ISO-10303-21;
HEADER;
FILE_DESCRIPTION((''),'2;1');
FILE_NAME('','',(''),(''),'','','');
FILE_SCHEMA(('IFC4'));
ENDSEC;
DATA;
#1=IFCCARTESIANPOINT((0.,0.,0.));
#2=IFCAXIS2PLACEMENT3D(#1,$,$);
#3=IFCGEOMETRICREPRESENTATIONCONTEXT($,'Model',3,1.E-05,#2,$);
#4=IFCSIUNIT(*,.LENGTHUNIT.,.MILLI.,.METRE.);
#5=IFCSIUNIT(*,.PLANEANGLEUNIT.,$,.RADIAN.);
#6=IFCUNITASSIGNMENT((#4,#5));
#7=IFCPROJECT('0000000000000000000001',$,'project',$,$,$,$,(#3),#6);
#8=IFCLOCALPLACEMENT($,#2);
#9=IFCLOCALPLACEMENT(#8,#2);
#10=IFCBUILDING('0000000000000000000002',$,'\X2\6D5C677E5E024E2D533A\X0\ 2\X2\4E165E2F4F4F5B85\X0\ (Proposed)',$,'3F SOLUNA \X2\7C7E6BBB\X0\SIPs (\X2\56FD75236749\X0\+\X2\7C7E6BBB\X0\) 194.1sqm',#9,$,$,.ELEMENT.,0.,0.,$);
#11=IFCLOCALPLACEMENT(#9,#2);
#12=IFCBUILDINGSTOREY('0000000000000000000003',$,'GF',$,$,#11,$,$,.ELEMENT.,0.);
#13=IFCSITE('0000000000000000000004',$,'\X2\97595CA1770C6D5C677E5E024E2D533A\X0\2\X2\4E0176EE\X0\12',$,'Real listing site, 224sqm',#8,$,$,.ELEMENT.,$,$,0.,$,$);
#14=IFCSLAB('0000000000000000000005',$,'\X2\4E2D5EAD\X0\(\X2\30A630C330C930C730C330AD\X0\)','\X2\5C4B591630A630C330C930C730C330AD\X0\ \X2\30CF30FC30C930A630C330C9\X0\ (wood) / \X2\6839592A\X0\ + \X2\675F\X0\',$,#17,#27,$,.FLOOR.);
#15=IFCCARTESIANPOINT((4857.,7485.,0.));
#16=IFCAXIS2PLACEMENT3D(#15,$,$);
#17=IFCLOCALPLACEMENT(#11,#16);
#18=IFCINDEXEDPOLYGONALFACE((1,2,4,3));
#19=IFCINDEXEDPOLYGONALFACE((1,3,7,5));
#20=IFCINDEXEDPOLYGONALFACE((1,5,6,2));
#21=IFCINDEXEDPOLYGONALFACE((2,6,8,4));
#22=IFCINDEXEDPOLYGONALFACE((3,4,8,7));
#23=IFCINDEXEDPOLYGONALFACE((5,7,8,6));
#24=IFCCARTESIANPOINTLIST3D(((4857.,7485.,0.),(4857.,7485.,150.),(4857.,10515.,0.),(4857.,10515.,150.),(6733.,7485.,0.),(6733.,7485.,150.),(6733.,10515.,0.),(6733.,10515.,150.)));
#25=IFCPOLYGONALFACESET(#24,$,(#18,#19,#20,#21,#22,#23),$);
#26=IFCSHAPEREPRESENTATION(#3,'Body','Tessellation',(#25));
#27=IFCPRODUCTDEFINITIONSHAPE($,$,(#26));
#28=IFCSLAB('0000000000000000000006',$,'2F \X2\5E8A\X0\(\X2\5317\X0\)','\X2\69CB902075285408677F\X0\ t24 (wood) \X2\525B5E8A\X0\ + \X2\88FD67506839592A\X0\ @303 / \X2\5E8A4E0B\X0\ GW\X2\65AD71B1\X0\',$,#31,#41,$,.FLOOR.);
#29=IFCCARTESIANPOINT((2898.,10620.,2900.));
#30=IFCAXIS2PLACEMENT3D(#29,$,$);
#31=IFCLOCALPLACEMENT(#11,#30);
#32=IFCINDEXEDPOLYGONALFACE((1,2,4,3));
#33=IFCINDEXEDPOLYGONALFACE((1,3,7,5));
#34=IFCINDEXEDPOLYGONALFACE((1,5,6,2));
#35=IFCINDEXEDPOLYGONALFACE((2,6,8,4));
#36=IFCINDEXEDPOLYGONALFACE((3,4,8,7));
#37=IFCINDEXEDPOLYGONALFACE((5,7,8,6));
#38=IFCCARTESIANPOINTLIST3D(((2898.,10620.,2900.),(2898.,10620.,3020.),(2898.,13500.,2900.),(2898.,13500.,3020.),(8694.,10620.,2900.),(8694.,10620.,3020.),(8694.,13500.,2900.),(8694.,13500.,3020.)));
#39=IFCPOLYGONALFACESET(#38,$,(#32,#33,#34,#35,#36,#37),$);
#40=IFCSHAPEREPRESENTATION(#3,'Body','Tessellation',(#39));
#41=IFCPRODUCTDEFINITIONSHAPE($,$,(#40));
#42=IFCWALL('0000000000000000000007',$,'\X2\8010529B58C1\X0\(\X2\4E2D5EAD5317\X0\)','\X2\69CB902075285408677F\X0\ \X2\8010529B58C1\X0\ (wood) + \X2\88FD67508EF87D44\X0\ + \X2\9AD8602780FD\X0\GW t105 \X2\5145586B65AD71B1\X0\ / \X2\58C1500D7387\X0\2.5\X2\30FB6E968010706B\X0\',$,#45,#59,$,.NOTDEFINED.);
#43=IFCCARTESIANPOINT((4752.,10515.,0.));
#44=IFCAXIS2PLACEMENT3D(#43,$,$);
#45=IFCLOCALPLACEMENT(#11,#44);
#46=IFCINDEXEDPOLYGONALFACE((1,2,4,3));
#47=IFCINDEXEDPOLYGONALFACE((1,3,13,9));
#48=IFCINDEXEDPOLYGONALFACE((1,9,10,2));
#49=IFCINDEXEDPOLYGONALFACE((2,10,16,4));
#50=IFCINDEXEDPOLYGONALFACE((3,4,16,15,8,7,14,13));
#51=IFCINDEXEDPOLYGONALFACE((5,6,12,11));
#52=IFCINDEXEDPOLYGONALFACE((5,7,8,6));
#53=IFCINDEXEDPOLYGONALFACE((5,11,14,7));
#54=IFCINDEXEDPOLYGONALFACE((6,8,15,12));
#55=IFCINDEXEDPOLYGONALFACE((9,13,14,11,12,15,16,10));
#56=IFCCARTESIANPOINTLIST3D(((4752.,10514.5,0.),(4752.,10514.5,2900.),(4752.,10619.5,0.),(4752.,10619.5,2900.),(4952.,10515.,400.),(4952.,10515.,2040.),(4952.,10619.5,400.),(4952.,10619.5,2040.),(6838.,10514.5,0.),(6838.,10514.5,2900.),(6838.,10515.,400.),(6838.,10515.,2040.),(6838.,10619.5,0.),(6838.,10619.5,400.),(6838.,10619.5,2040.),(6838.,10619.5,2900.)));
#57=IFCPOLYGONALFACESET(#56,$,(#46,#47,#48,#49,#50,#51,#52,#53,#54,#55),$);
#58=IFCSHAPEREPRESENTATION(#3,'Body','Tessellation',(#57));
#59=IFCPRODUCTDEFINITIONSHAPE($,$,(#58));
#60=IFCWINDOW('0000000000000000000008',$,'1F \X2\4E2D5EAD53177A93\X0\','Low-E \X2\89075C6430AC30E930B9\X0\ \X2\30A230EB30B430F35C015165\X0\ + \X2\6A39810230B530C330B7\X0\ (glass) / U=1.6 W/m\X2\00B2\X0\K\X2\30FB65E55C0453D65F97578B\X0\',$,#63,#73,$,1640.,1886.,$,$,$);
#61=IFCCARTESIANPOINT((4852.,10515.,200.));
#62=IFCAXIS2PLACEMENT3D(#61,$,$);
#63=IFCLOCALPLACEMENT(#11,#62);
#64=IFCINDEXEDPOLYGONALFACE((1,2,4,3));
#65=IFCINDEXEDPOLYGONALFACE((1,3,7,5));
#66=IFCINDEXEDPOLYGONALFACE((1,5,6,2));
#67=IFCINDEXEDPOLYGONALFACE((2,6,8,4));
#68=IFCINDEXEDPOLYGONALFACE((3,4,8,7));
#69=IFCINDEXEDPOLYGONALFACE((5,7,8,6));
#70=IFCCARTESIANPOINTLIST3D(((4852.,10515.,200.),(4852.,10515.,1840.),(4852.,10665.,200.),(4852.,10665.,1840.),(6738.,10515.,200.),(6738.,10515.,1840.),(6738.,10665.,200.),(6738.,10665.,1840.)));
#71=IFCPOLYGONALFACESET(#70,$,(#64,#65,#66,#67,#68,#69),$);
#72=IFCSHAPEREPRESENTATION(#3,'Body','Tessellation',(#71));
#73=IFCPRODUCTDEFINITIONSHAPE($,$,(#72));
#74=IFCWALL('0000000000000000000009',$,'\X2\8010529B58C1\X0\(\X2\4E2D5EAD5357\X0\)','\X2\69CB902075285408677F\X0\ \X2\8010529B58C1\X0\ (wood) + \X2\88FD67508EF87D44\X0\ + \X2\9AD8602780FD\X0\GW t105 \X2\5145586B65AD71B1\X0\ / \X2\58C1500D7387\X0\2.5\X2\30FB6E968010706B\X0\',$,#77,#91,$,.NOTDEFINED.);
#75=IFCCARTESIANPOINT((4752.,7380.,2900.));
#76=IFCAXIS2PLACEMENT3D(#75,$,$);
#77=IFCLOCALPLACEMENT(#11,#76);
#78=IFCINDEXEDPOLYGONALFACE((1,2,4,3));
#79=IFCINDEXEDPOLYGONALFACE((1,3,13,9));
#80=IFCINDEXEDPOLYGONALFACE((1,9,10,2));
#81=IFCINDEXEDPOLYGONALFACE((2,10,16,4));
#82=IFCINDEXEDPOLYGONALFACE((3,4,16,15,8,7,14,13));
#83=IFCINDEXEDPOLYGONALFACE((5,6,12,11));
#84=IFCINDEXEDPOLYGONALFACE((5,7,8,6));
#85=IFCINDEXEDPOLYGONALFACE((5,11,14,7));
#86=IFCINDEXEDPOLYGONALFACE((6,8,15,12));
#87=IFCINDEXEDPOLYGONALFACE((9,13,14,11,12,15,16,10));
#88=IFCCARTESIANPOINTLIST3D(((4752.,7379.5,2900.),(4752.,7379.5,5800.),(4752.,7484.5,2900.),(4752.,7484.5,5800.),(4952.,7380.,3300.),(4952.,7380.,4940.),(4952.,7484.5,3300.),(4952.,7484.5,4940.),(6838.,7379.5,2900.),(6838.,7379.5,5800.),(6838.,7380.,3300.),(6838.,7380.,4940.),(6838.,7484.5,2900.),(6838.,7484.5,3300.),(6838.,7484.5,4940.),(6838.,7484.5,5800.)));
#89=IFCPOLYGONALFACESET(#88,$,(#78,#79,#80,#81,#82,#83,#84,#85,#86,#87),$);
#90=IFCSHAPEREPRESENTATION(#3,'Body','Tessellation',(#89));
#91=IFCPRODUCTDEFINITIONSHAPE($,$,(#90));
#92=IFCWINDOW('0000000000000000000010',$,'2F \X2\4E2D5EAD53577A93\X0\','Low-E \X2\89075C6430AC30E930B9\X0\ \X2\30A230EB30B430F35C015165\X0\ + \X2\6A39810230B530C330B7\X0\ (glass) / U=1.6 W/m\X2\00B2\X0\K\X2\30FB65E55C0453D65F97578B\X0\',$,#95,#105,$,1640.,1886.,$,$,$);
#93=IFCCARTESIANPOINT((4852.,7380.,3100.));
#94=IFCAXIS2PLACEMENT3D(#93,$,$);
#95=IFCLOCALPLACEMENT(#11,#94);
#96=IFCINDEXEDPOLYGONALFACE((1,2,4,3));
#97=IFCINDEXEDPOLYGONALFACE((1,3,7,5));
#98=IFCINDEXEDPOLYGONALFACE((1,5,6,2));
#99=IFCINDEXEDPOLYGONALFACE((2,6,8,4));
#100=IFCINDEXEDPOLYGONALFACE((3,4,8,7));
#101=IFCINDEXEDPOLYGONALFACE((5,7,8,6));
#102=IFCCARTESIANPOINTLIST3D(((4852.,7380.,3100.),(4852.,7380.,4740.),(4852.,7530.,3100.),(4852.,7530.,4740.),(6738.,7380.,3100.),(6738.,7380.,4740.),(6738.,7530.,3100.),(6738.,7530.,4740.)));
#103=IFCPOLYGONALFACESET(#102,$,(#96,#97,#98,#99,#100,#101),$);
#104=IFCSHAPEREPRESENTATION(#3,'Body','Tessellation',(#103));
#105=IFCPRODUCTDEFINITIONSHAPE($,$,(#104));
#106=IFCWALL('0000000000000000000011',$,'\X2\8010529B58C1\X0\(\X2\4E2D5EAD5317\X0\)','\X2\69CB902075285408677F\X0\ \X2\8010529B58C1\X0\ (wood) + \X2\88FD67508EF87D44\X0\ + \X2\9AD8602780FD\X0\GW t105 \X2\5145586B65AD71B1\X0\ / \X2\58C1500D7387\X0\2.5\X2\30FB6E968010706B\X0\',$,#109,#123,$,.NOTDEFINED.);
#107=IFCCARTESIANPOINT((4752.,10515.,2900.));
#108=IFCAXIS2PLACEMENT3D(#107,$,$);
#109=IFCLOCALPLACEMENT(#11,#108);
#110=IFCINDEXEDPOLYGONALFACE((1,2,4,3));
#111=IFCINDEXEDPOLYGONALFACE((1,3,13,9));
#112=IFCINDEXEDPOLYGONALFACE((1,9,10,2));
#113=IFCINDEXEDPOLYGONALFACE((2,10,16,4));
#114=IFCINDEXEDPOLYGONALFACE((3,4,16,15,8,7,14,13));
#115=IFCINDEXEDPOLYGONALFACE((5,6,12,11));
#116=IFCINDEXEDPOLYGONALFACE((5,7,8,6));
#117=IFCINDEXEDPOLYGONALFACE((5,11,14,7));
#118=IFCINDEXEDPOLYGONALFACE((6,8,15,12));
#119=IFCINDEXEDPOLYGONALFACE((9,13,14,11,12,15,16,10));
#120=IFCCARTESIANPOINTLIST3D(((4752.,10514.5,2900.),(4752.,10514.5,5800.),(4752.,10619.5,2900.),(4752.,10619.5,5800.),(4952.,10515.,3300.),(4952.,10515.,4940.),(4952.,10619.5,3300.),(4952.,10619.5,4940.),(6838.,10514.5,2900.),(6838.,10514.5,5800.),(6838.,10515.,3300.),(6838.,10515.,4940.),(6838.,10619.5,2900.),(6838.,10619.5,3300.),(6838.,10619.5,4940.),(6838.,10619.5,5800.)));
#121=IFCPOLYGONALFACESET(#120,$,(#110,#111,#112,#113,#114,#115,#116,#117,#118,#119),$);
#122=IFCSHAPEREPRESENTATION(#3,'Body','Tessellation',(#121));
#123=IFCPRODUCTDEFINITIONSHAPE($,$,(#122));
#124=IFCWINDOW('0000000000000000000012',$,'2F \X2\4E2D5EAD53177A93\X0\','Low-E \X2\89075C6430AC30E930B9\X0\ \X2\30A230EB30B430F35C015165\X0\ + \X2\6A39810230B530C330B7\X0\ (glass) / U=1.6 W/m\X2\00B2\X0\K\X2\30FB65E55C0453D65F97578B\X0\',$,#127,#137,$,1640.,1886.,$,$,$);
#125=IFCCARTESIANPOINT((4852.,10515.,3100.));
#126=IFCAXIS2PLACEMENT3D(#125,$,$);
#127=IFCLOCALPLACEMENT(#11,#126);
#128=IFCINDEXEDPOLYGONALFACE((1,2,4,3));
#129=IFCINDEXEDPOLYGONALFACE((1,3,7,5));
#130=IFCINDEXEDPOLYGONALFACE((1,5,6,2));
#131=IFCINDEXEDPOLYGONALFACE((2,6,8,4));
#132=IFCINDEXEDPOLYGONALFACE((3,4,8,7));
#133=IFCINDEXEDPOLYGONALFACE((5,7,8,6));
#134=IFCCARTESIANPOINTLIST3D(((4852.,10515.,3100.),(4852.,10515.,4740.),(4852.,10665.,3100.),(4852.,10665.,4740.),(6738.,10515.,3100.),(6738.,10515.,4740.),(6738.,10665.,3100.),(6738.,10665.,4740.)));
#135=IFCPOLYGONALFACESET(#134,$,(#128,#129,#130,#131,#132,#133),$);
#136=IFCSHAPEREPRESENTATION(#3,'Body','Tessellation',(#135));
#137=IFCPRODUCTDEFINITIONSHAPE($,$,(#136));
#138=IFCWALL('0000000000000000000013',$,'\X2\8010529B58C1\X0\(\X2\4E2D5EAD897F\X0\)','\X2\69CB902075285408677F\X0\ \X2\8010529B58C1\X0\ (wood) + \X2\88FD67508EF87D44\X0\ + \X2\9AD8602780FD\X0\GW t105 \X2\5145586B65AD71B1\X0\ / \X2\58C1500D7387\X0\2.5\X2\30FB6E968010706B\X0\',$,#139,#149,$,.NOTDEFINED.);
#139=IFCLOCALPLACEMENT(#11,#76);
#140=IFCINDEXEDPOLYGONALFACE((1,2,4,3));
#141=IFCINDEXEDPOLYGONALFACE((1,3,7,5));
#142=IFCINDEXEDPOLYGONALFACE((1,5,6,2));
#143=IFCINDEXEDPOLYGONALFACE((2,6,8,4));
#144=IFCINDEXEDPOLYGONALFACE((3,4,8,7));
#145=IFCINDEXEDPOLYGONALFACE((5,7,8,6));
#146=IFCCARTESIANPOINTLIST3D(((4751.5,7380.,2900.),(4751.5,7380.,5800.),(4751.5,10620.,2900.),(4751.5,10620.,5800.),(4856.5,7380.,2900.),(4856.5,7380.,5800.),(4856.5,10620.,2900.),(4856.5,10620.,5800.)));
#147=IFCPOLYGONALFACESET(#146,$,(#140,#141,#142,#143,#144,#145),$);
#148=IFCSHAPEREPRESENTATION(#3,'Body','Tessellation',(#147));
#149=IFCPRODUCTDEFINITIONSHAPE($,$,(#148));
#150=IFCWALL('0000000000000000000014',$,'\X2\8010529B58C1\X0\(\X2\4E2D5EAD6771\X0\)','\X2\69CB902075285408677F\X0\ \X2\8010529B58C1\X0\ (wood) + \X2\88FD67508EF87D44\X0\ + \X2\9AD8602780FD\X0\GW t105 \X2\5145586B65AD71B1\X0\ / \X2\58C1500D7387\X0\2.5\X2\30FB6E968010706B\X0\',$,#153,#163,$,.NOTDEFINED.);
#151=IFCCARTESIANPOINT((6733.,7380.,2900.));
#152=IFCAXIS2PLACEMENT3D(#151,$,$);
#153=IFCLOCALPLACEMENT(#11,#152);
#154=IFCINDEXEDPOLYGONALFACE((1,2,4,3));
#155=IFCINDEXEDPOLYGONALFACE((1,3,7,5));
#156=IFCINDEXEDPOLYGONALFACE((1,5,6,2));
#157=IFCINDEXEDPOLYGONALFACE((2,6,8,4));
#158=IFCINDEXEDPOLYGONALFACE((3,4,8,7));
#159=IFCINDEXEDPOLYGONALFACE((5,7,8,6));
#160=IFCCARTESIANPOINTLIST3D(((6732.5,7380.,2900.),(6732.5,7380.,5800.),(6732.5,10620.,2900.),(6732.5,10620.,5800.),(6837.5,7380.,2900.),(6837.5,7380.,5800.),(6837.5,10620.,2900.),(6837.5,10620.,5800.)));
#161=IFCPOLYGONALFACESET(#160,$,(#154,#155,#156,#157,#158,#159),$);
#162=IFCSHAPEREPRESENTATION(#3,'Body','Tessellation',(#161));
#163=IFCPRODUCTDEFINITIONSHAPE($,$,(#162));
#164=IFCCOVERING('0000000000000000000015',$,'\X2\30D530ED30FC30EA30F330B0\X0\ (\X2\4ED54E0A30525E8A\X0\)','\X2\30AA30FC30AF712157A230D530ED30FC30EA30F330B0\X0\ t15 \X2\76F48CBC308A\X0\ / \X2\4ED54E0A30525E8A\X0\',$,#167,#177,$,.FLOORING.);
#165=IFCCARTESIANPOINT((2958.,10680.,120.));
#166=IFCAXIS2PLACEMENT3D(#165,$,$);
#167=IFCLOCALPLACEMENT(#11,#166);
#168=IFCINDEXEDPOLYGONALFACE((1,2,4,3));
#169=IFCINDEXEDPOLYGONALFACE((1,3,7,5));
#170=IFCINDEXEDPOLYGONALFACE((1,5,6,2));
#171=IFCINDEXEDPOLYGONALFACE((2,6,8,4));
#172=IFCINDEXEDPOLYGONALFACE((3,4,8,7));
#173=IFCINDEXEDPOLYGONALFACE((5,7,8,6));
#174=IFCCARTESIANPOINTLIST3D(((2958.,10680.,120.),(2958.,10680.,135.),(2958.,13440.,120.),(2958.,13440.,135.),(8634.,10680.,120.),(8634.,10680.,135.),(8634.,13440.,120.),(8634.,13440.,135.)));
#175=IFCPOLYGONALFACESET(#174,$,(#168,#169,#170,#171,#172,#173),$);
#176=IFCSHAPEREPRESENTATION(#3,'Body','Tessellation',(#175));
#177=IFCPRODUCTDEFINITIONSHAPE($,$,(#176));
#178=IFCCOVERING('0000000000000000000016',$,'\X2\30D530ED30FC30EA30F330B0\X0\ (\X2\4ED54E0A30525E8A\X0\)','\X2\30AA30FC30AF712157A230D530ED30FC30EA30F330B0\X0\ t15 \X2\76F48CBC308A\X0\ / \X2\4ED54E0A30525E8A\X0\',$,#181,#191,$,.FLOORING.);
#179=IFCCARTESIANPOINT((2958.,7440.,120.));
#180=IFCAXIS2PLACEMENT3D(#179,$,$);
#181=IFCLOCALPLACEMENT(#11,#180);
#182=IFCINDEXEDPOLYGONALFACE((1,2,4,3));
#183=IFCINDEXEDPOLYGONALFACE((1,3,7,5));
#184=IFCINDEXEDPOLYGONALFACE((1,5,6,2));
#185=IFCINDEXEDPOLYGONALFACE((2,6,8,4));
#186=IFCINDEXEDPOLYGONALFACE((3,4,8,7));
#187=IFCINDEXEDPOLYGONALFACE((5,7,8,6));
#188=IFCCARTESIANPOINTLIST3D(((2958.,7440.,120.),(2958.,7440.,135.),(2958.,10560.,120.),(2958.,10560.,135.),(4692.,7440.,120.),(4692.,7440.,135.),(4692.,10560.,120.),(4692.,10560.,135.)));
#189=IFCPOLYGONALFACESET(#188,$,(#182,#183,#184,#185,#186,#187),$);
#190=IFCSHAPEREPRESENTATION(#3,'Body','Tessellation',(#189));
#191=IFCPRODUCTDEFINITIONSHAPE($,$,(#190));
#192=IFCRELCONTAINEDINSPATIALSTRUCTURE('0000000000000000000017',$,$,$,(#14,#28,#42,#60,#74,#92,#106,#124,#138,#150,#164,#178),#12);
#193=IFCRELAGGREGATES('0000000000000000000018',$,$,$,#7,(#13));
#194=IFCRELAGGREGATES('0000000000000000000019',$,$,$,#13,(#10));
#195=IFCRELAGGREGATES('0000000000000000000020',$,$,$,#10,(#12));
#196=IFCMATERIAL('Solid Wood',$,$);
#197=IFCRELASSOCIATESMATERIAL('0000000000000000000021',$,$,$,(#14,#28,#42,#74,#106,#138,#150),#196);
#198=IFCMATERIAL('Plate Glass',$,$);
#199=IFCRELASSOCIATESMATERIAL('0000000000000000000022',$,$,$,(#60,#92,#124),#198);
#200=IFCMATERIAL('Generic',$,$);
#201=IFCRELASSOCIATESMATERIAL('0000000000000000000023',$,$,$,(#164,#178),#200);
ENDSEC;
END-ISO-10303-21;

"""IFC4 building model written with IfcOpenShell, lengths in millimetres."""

from ifc_helpers import new_model, si_unit, frame, frame_2d, origin, place, context, project, spatial, rectangle, extrude, material, element, fill, save


model = new_model("IFC4")

# Units and contexts
model_context = context("Model", 3, precision=1e-05, world=origin())
ifc_project = project(units=[si_unit("LENGTHUNIT", "METRE", prefix="MILLI"), si_unit("PLANEANGLEUNIT", "RADIAN")], contexts=[model_context])

# Site, building, storey
site_placement = place(None, origin())
site = spatial("IfcSite", under=ifc_project, at=site_placement, Name="静岡県浜松市中区2丁目12", ObjectType="Real listing site, 224sqm", CompositionType="ELEMENT", RefElevation=0.0)
building_placement = place(site_placement, origin())
building = spatial("IfcBuilding", under=site, at=building_placement, Name="浜松市中区 2世帯住宅 (Proposed)", ObjectType="3F SOLUNA 籾殻SIPs (国産杉+籾殻) 194.1sqm", CompositionType="ELEMENT", ElevationOfRefHeight=0.0, ElevationOfTerrain=0.0)
storey_placement = place(building_placement, origin())
storey = spatial("IfcBuildingStorey", under=building, at=storey_placement, Name="GF", CompositionType="ELEMENT", Elevation=0.0)

# Slabs
ifc_material_1 = material(Name="Solid Wood")
slab_1_placement = place(storey_placement, frame((4857.0, 7485.0, 0.0)))
element("IfcSlab", 1, at=slab_1_placement, inside=storey, material=ifc_material_1, Name="中庭(ウッドデッキ)", Description="屋外ウッドデッキ ハードウッド (wood) / 根太 + 束", PredefinedType="FLOOR", context=model_context, shape_type="SweptSolid", body=[
    extrude(rectangle(XDim=1876.0, YDim=3030.0, at=frame_2d((938.0, 1515.0))), frame((4857.0, 7485.0, 0.0)), (0.0, 0.0, 1.0), 150.0),
])
slab_2_placement = place(storey_placement, frame((2898.0, 10620.0, 2900.0)))
element("IfcSlab", 2, at=slab_2_placement, inside=storey, material=ifc_material_1, Name="2F 床(北)", Description="構造用合板 t24 (wood) 剛床 + 製材根太 @303 / 床下 GW断熱", PredefinedType="FLOOR", context=model_context, shape_type="SweptSolid", body=[
    extrude(rectangle(XDim=5796.0, YDim=2880.0, at=frame_2d((2898.0, 1440.0))), frame((2898.0, 10620.0, 2900.0)), (0.0, 0.0, 1.0), 120.0),
])

# Wall, opening, window
wall_1_placement = place(storey_placement, frame((4752.0, 10515.0, 0.0)))
wall_1 = element("IfcWall", 3, at=wall_1_placement, inside=storey, material=ifc_material_1, Name="耐力壁(中庭北)", Description="構造用合板 耐力壁 (wood) + 製材軸組 + 高性能GW t105 充填断熱 / 壁倍率2.5・準耐火", PredefinedType="NOTDEFINED", context=model_context, shape_type="SweptSolid", body=[
    extrude(rectangle(XDim=2086.0, YDim=105.0, at=frame_2d((1043.0, 52.0))), frame((4752.0, 10515.0, 0.0)), (0.0, 0.0, 1.0), 2900.0),
])
opening_1_placement = place(storey_placement, frame((4852.0, 10515.0, 200.0)))
opening_1 = element("IfcOpeningElement", 4, at=opening_1_placement, cuts=wall_1, PredefinedType="NOTDEFINED", context=model_context, shape_type="SweptSolid", body=[
    extrude(rectangle(XDim=1886.0, YDim=150.0, at=frame_2d((943.0, 75.0))), frame((4852.0, 10515.0, 200.0)), (0.0, 0.0, 1.0), 1640.0),
])
ifc_material_2 = material(Name="Plate Glass")
window_1_placement = place(storey_placement, frame((4852.0, 10515.0, 200.0)))
window_1 = element("IfcWindow", 5, at=window_1_placement, inside=storey, material=ifc_material_2, Name="1F 中庭北窓", Description="Low-E 複層ガラス アルゴン封入 + 樹脂サッシ (glass) / U=1.6 W/m²K・日射取得型", OverallHeight=1640.0, OverallWidth=1886.0, context=model_context, shape_type="SweptSolid", body=[
    extrude(rectangle(XDim=1886.0, YDim=150.0, at=frame_2d((943.0, 75.0))), frame((4852.0, 10515.0, 200.0)), (0.0, 0.0, 1.0), 1640.0),
])
fill(opening_1, window_1)

# Walls, openings, windows
wall_2_placement = place(storey_placement, frame((4752.0, 7380.0, 2900.0)))
wall_2 = element("IfcWall", 6, at=wall_2_placement, inside=storey, material=ifc_material_1, Name="耐力壁(中庭南)", Description="構造用合板 耐力壁 (wood) + 製材軸組 + 高性能GW t105 充填断熱 / 壁倍率2.5・準耐火", PredefinedType="NOTDEFINED", context=model_context, shape_type="SweptSolid", body=[
    extrude(rectangle(XDim=2086.0, YDim=105.0, at=frame_2d((1043.0, 52.0))), frame((4752.0, 7380.0, 2900.0)), (0.0, 0.0, 1.0), 2900.0),
])
opening_2_placement = place(storey_placement, frame((4852.0, 7380.0, 3100.0)))
opening_2 = element("IfcOpeningElement", 7, at=opening_2_placement, cuts=wall_2, PredefinedType="NOTDEFINED", context=model_context, shape_type="SweptSolid", body=[
    extrude(rectangle(XDim=1886.0, YDim=150.0, at=frame_2d((943.0, 75.0))), frame((4852.0, 7380.0, 3100.0)), (0.0, 0.0, 1.0), 1640.0),
])
window_2_placement = place(storey_placement, frame((4852.0, 7380.0, 3100.0)))
window_2 = element("IfcWindow", 8, at=window_2_placement, inside=storey, material=ifc_material_2, Name="2F 中庭南窓", Description="Low-E 複層ガラス アルゴン封入 + 樹脂サッシ (glass) / U=1.6 W/m²K・日射取得型", OverallHeight=1640.0, OverallWidth=1886.0, context=model_context, shape_type="SweptSolid", body=[
    extrude(rectangle(XDim=1886.0, YDim=150.0, at=frame_2d((943.0, 75.0))), frame((4852.0, 7380.0, 3100.0)), (0.0, 0.0, 1.0), 1640.0),
])
fill(opening_2, window_2)
wall_3_placement = place(storey_placement, frame((4752.0, 10515.0, 2900.0)))
wall_3 = element("IfcWall", 9, at=wall_3_placement, inside=storey, material=ifc_material_1, Name="耐力壁(中庭北)", Description="構造用合板 耐力壁 (wood) + 製材軸組 + 高性能GW t105 充填断熱 / 壁倍率2.5・準耐火", PredefinedType="NOTDEFINED", context=model_context, shape_type="SweptSolid", body=[
    extrude(rectangle(XDim=2086.0, YDim=105.0, at=frame_2d((1043.0, 52.0))), frame((4752.0, 10515.0, 2900.0)), (0.0, 0.0, 1.0), 2900.0),
])
opening_3_placement = place(storey_placement, frame((4852.0, 10515.0, 3100.0)))
opening_3 = element("IfcOpeningElement", 10, at=opening_3_placement, cuts=wall_3, PredefinedType="NOTDEFINED", context=model_context, shape_type="SweptSolid", body=[
    extrude(rectangle(XDim=1886.0, YDim=150.0, at=frame_2d((943.0, 75.0))), frame((4852.0, 10515.0, 3100.0)), (0.0, 0.0, 1.0), 1640.0),
])
window_3_placement = place(storey_placement, frame((4852.0, 10515.0, 3100.0)))
window_3 = element("IfcWindow", 11, at=window_3_placement, inside=storey, material=ifc_material_2, Name="2F 中庭北窓", Description="Low-E 複層ガラス アルゴン封入 + 樹脂サッシ (glass) / U=1.6 W/m²K・日射取得型", OverallHeight=1640.0, OverallWidth=1886.0, context=model_context, shape_type="SweptSolid", body=[
    extrude(rectangle(XDim=1886.0, YDim=150.0, at=frame_2d((943.0, 75.0))), frame((4852.0, 10515.0, 3100.0)), (0.0, 0.0, 1.0), 1640.0),
])
fill(opening_3, window_3)

# Walls
wall_4_placement = place(storey_placement, frame((4752.0, 7380.0, 2900.0)))
element("IfcWall", 12, at=wall_4_placement, inside=storey, material=ifc_material_1, Name="耐力壁(中庭西)", Description="構造用合板 耐力壁 (wood) + 製材軸組 + 高性能GW t105 充填断熱 / 壁倍率2.5・準耐火", PredefinedType="NOTDEFINED", context=model_context, shape_type="SweptSolid", body=[
    extrude(rectangle(XDim=105.0, YDim=3240.0, at=frame_2d((52.0, 1620.0))), frame((4752.0, 7380.0, 2900.0)), (0.0, 0.0, 1.0), 2900.0),
])
wall_5_placement = place(storey_placement, frame((6733.0, 7380.0, 2900.0)))
element("IfcWall", 13, at=wall_5_placement, inside=storey, material=ifc_material_1, Name="耐力壁(中庭東)", Description="構造用合板 耐力壁 (wood) + 製材軸組 + 高性能GW t105 充填断熱 / 壁倍率2.5・準耐火", PredefinedType="NOTDEFINED", context=model_context, shape_type="SweptSolid", body=[
    extrude(rectangle(XDim=105.0, YDim=3240.0, at=frame_2d((52.0, 1620.0))), frame((6733.0, 7380.0, 2900.0)), (0.0, 0.0, 1.0), 2900.0),
])

# Coverings
ifc_material_3 = material(Name="Generic")
covering_1_placement = place(storey_placement, frame((2958.0, 10680.0, 120.0)))
element("IfcCovering", 14, at=covering_1_placement, inside=storey, material=ifc_material_3, Name="フローリング (仕上げ床)", Description="オーク無垢フローリング t15 直貼り / 仕上げ床", PredefinedType="FLOORING", context=model_context, shape_type="SweptSolid", body=[
    extrude(rectangle(XDim=5676.0, YDim=2760.0, at=frame_2d((2838.0, 1380.0))), frame((2958.0, 10680.0, 120.0)), (0.0, 0.0, 1.0), 15.0),
])
covering_2_placement = place(storey_placement, frame((2958.0, 7440.0, 120.0)))
element("IfcCovering", 15, at=covering_2_placement, inside=storey, material=ifc_material_3, Name="フローリング (仕上げ床)", Description="オーク無垢フローリング t15 直貼り / 仕上げ床", PredefinedType="FLOORING", context=model_context, shape_type="SweptSolid", body=[
    extrude(rectangle(XDim=1734.0, YDim=3120.0, at=frame_2d((867.0, 1560.0))), frame((2958.0, 7440.0, 120.0)), (0.0, 0.0, 1.0), 15.0),
])

save(model, "model.ifc")
